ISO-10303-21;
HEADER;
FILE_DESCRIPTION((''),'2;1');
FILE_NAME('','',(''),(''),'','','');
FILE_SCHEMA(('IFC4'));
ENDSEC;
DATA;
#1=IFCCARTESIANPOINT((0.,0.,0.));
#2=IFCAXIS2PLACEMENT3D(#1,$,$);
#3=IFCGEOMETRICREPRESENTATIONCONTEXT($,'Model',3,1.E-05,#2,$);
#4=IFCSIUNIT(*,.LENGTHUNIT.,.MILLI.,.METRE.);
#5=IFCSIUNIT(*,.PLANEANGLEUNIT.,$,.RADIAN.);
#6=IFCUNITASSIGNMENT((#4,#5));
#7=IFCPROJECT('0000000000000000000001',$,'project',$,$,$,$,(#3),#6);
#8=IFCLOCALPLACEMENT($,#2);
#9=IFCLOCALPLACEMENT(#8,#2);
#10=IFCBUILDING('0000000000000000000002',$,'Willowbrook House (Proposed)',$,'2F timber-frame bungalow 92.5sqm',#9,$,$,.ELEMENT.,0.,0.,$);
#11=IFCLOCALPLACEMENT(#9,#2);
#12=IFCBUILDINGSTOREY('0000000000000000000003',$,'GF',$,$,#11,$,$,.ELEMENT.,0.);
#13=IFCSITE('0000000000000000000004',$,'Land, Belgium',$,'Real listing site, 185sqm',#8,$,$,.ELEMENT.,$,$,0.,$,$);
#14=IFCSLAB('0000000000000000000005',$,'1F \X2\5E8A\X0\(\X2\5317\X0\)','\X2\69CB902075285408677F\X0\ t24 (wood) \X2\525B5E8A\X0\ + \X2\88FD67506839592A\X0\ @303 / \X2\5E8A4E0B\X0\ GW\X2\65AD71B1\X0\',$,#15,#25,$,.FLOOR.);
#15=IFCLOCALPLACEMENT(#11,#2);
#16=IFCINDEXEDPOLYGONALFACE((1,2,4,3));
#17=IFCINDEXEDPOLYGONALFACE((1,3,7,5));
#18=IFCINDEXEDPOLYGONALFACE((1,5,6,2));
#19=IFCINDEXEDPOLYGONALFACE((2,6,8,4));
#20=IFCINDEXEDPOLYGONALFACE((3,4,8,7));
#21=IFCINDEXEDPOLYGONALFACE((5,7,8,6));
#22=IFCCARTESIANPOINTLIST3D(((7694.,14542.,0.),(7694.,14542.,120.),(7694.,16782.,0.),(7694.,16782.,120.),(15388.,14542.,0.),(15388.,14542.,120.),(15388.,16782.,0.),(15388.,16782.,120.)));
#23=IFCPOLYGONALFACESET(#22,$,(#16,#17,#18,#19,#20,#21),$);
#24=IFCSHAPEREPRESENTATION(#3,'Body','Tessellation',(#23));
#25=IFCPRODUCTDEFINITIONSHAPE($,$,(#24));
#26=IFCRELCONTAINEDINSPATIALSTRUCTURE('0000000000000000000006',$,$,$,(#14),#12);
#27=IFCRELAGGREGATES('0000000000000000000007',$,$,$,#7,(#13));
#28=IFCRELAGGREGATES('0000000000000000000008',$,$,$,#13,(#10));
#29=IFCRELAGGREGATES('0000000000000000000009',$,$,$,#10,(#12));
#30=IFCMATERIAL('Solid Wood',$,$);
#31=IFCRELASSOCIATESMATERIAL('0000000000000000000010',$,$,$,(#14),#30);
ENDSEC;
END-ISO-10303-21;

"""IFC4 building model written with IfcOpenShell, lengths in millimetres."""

from ifc_helpers import new_model, si_unit, frame, frame_2d, origin, place, context, project, spatial, rectangle, extrude, material, element, save


model = new_model("IFC4")

# Units and contexts
model_context = context("Model", 3, precision=1e-05, world=origin())
ifc_project = project(units=[si_unit("LENGTHUNIT", "METRE", prefix="MILLI"), si_unit("PLANEANGLEUNIT", "RADIAN")], contexts=[model_context])

# Site, building, storey
site_placement = place(None, origin())
site = spatial("IfcSite", under=ifc_project, at=site_placement, Name="Land, Belgium", ObjectType="Real listing site, 185sqm", CompositionType="ELEMENT", RefElevation=0.0)
building_placement = place(site_placement, origin())
building = spatial("IfcBuilding", under=site, at=building_placement, Name="Willowbrook House (Proposed)", ObjectType="2F timber-frame bungalow 92.5sqm", CompositionType="ELEMENT", ElevationOfRefHeight=0.0, ElevationOfTerrain=0.0)
storey_placement = place(building_placement, origin())
storey = spatial("IfcBuildingStorey", under=building, at=storey_placement, Name="GF", CompositionType="ELEMENT", Elevation=0.0)

# Slab
ifc_material_1 = material(Name="Solid Wood")
slab_1_placement = place(storey_placement, frame((3847.0, 7271.0, 0.0)))
element("IfcSlab", 1, at=slab_1_placement, inside=storey, material=ifc_material_1, Name="1F 床(北)", Description="構造用合板 t24 (wood) 剛床 + 製材根太 @303 / 床下 GW断熱", PredefinedType="FLOOR", context=model_context, shape_type="SweptSolid", body=[
    extrude(rectangle(XDim=7694.0, YDim=2240.0, at=frame_2d((3847.0, 1120.0))), frame((3847.0, 7271.0, 0.0)), (0.0, 0.0, 1.0), 120.0),
])

save(model, "model.ifc")
